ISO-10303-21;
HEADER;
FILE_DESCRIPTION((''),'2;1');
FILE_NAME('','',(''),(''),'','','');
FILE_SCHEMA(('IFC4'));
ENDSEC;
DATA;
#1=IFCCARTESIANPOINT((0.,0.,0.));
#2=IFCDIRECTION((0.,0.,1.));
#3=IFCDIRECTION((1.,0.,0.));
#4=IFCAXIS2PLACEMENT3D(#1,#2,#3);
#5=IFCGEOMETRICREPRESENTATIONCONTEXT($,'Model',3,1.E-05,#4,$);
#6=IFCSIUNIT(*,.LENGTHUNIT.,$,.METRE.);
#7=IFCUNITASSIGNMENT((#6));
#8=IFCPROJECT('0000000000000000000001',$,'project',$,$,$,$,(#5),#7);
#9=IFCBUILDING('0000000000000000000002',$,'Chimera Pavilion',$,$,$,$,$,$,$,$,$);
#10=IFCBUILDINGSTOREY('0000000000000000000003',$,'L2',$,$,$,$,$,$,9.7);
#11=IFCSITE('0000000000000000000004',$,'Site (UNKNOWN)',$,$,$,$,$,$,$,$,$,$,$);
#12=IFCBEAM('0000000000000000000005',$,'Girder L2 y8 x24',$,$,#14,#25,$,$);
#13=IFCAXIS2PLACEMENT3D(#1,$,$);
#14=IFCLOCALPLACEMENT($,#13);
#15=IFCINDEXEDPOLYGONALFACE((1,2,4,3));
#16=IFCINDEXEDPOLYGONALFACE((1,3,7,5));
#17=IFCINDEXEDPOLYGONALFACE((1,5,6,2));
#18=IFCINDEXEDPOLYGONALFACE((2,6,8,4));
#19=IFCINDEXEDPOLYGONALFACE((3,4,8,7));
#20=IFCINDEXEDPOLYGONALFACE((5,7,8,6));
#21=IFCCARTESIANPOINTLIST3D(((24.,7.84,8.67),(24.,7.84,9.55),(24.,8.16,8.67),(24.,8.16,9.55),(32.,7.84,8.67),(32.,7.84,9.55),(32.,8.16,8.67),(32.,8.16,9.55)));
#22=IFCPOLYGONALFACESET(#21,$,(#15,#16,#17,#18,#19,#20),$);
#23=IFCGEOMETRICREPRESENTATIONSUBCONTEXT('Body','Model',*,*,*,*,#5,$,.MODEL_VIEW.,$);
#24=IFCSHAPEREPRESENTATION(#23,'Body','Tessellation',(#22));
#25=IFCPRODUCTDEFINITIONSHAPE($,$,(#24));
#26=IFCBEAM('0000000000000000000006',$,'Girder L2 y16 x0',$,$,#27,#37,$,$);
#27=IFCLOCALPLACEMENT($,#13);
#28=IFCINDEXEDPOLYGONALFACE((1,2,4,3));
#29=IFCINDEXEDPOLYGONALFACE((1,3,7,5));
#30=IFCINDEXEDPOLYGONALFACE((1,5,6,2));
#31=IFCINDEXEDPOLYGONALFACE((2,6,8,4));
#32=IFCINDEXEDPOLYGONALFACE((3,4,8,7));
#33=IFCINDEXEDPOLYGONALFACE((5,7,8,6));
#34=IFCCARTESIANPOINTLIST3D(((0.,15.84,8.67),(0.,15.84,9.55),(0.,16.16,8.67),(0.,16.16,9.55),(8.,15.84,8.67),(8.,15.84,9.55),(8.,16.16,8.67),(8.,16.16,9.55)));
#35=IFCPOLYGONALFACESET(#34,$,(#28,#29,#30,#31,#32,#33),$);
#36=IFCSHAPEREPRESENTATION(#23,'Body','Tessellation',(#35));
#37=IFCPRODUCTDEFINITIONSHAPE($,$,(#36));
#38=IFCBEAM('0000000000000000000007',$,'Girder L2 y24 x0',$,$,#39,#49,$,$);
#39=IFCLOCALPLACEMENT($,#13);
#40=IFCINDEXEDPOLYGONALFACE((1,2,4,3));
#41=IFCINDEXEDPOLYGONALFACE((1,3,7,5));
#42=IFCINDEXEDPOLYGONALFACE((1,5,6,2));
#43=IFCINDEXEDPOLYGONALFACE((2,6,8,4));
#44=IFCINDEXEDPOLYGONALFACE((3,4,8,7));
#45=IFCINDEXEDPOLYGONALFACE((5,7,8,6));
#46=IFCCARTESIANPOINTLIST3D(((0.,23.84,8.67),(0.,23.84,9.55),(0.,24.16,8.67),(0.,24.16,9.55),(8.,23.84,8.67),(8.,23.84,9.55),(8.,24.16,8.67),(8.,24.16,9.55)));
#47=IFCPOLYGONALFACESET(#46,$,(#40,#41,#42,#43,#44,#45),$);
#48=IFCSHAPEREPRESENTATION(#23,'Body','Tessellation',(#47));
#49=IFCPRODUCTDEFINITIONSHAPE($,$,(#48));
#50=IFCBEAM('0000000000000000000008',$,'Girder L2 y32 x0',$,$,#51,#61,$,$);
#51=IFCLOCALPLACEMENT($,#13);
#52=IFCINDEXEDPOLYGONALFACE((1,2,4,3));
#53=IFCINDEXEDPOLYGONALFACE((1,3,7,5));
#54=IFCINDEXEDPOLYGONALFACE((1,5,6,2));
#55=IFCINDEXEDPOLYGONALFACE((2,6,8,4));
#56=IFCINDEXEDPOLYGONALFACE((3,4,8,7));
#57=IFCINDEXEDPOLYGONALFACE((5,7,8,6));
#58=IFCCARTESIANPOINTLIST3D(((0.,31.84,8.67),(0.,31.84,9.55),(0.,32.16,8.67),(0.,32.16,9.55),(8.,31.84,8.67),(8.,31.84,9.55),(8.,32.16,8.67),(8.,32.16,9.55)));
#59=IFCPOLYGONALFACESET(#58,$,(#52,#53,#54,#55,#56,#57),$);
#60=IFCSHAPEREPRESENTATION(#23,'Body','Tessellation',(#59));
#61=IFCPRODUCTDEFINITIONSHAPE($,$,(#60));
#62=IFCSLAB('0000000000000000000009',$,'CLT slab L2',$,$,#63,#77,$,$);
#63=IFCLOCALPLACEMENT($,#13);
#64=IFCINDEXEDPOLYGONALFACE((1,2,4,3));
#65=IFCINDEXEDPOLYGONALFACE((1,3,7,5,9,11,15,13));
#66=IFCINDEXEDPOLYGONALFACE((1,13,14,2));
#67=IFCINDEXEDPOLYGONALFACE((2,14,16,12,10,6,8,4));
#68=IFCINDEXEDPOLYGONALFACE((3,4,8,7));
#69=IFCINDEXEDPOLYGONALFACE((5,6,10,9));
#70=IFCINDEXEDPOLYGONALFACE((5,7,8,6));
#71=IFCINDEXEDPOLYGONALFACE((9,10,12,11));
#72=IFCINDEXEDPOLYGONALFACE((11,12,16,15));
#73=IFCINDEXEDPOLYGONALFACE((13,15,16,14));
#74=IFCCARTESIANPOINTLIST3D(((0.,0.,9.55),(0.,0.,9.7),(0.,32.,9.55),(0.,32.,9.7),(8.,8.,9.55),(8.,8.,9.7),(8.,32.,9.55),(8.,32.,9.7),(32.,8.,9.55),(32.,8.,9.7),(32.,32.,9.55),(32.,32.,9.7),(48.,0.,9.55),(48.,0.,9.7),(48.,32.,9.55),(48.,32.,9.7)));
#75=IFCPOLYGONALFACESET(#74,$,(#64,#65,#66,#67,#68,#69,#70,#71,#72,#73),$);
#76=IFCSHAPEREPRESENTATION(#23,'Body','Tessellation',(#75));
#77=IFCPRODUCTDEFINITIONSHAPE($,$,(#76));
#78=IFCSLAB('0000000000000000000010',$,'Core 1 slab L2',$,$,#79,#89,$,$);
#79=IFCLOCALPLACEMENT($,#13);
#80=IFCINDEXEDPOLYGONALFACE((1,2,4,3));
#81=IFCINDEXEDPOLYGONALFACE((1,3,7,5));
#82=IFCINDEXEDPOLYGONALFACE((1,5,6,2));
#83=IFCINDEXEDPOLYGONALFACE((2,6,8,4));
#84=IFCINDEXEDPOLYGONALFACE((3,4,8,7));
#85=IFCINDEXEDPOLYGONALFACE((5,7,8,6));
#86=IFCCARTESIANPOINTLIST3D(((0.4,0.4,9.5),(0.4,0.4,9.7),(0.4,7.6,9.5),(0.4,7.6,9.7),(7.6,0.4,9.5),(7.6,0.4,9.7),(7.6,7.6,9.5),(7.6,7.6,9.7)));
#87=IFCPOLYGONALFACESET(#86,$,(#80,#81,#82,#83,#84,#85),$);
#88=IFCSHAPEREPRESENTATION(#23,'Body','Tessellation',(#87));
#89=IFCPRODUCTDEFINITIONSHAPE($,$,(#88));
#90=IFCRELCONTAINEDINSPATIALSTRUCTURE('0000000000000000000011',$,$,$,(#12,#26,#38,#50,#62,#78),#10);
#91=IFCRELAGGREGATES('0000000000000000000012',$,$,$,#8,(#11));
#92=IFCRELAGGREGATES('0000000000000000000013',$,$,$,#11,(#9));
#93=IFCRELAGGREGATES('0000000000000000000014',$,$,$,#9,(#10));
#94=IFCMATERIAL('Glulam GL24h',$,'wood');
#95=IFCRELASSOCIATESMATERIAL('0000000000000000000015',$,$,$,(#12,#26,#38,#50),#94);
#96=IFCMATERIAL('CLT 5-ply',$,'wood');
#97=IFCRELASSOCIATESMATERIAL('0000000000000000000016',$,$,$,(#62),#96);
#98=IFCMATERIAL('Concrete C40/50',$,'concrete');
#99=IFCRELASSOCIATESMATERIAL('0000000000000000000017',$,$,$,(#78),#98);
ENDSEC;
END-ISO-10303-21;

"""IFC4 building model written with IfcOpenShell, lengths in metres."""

from ifc_helpers import new_model, si_unit, frame, origin_with_axes, place, context, subcontext, project, spatial, polyline, rectangle, outline, extrude, material, element, save


model = new_model("IFC4")

# Units and contexts
model_context = context("Model", 3, precision=1e-05, world=origin_with_axes())
body_context = subcontext(model_context, "Body", "Model", "MODEL_VIEW")
ifc_project = project(units=[si_unit("LENGTHUNIT", "METRE")], contexts=[model_context])

# Site, building, storey
site = spatial("IfcSite", under=ifc_project, Name="Site (UNKNOWN)")
building = spatial("IfcBuilding", under=site, Name="Chimera Pavilion")
storey = spatial("IfcBuildingStorey", under=building, Name="L2", Elevation=9.7)

# Beams
ifc_material_1 = material(Name="Glulam GL24h", Category="wood")
for number, where, z_axis, x_axis, name in (
    (1, (24.0, 8.0, 9.11), (1.0, 0.0, 0.0), (0.0, -1.0, 0.0), "Girder L2 y8 x24"),
    (2, (0.0, 16.0, 9.11), (1.0, 0.0, 0.0), (0.0, -1.0, 0.0), "Girder L2 y16 x0"),
    (3, (0.0, 24.0, 9.11), (1.0, 0.0, 0.0), (0.0, -1.0, 0.0), "Girder L2 y24 x0"),
    (4, (0.0, 32.0, 9.11), (1.0, 0.0, 0.0), (0.0, -1.0, 0.0), "Girder L2 y32 x0"),
):
    element("IfcBeam", number, at=place(None, frame(where, z_axis=z_axis, x_axis=x_axis)), inside=storey, material=ifc_material_1, Name=name, context=body_context, shape_type="SweptSolid", body=[
        extrude(rectangle(XDim=0.32, YDim=0.88), origin_with_axes(), (0.0, 0.0, 1.0), 8.0),
    ])

# Slabs
ifc_material_2 = material(Name="CLT 5-ply", Category="wood")
slab_1_placement = place(None, frame((0.0, 0.0, 9.55), z_axis=(0.0, 0.0, 1.0), x_axis=(1.0, 0.0, 0.0)))
element("IfcSlab", 5, at=slab_1_placement, inside=storey, material=ifc_material_2, Name="CLT slab L2", context=body_context, shape_type="SweptSolid", body=[
    extrude(outline(polyline([(0.0, 0.0), (48.0, 0.0), (48.0, 32.0), (32.0, 32.0), (32.0, 8.0), (8.0, 8.0), (8.0, 32.0), (0.0, 32.0), (0.0, 0.0)])), origin_with_axes(), (0.0, 0.0, 1.0), 0.15),
])
ifc_material_3 = material(Name="Concrete C40/50", Category="concrete")
slab_2_placement = place(None, frame((4.0, 4.0, 9.5), z_axis=(0.0, 0.0, 1.0), x_axis=(1.0, 0.0, 0.0)))
element("IfcSlab", 6, at=slab_2_placement, inside=storey, material=ifc_material_3, Name="Core 1 slab L2", context=body_context, shape_type="SweptSolid", body=[
    extrude(rectangle(XDim=7.2, YDim=7.2), origin_with_axes(), (0.0, 0.0, 1.0), 0.2),
])

save(model, "model.ifc")
